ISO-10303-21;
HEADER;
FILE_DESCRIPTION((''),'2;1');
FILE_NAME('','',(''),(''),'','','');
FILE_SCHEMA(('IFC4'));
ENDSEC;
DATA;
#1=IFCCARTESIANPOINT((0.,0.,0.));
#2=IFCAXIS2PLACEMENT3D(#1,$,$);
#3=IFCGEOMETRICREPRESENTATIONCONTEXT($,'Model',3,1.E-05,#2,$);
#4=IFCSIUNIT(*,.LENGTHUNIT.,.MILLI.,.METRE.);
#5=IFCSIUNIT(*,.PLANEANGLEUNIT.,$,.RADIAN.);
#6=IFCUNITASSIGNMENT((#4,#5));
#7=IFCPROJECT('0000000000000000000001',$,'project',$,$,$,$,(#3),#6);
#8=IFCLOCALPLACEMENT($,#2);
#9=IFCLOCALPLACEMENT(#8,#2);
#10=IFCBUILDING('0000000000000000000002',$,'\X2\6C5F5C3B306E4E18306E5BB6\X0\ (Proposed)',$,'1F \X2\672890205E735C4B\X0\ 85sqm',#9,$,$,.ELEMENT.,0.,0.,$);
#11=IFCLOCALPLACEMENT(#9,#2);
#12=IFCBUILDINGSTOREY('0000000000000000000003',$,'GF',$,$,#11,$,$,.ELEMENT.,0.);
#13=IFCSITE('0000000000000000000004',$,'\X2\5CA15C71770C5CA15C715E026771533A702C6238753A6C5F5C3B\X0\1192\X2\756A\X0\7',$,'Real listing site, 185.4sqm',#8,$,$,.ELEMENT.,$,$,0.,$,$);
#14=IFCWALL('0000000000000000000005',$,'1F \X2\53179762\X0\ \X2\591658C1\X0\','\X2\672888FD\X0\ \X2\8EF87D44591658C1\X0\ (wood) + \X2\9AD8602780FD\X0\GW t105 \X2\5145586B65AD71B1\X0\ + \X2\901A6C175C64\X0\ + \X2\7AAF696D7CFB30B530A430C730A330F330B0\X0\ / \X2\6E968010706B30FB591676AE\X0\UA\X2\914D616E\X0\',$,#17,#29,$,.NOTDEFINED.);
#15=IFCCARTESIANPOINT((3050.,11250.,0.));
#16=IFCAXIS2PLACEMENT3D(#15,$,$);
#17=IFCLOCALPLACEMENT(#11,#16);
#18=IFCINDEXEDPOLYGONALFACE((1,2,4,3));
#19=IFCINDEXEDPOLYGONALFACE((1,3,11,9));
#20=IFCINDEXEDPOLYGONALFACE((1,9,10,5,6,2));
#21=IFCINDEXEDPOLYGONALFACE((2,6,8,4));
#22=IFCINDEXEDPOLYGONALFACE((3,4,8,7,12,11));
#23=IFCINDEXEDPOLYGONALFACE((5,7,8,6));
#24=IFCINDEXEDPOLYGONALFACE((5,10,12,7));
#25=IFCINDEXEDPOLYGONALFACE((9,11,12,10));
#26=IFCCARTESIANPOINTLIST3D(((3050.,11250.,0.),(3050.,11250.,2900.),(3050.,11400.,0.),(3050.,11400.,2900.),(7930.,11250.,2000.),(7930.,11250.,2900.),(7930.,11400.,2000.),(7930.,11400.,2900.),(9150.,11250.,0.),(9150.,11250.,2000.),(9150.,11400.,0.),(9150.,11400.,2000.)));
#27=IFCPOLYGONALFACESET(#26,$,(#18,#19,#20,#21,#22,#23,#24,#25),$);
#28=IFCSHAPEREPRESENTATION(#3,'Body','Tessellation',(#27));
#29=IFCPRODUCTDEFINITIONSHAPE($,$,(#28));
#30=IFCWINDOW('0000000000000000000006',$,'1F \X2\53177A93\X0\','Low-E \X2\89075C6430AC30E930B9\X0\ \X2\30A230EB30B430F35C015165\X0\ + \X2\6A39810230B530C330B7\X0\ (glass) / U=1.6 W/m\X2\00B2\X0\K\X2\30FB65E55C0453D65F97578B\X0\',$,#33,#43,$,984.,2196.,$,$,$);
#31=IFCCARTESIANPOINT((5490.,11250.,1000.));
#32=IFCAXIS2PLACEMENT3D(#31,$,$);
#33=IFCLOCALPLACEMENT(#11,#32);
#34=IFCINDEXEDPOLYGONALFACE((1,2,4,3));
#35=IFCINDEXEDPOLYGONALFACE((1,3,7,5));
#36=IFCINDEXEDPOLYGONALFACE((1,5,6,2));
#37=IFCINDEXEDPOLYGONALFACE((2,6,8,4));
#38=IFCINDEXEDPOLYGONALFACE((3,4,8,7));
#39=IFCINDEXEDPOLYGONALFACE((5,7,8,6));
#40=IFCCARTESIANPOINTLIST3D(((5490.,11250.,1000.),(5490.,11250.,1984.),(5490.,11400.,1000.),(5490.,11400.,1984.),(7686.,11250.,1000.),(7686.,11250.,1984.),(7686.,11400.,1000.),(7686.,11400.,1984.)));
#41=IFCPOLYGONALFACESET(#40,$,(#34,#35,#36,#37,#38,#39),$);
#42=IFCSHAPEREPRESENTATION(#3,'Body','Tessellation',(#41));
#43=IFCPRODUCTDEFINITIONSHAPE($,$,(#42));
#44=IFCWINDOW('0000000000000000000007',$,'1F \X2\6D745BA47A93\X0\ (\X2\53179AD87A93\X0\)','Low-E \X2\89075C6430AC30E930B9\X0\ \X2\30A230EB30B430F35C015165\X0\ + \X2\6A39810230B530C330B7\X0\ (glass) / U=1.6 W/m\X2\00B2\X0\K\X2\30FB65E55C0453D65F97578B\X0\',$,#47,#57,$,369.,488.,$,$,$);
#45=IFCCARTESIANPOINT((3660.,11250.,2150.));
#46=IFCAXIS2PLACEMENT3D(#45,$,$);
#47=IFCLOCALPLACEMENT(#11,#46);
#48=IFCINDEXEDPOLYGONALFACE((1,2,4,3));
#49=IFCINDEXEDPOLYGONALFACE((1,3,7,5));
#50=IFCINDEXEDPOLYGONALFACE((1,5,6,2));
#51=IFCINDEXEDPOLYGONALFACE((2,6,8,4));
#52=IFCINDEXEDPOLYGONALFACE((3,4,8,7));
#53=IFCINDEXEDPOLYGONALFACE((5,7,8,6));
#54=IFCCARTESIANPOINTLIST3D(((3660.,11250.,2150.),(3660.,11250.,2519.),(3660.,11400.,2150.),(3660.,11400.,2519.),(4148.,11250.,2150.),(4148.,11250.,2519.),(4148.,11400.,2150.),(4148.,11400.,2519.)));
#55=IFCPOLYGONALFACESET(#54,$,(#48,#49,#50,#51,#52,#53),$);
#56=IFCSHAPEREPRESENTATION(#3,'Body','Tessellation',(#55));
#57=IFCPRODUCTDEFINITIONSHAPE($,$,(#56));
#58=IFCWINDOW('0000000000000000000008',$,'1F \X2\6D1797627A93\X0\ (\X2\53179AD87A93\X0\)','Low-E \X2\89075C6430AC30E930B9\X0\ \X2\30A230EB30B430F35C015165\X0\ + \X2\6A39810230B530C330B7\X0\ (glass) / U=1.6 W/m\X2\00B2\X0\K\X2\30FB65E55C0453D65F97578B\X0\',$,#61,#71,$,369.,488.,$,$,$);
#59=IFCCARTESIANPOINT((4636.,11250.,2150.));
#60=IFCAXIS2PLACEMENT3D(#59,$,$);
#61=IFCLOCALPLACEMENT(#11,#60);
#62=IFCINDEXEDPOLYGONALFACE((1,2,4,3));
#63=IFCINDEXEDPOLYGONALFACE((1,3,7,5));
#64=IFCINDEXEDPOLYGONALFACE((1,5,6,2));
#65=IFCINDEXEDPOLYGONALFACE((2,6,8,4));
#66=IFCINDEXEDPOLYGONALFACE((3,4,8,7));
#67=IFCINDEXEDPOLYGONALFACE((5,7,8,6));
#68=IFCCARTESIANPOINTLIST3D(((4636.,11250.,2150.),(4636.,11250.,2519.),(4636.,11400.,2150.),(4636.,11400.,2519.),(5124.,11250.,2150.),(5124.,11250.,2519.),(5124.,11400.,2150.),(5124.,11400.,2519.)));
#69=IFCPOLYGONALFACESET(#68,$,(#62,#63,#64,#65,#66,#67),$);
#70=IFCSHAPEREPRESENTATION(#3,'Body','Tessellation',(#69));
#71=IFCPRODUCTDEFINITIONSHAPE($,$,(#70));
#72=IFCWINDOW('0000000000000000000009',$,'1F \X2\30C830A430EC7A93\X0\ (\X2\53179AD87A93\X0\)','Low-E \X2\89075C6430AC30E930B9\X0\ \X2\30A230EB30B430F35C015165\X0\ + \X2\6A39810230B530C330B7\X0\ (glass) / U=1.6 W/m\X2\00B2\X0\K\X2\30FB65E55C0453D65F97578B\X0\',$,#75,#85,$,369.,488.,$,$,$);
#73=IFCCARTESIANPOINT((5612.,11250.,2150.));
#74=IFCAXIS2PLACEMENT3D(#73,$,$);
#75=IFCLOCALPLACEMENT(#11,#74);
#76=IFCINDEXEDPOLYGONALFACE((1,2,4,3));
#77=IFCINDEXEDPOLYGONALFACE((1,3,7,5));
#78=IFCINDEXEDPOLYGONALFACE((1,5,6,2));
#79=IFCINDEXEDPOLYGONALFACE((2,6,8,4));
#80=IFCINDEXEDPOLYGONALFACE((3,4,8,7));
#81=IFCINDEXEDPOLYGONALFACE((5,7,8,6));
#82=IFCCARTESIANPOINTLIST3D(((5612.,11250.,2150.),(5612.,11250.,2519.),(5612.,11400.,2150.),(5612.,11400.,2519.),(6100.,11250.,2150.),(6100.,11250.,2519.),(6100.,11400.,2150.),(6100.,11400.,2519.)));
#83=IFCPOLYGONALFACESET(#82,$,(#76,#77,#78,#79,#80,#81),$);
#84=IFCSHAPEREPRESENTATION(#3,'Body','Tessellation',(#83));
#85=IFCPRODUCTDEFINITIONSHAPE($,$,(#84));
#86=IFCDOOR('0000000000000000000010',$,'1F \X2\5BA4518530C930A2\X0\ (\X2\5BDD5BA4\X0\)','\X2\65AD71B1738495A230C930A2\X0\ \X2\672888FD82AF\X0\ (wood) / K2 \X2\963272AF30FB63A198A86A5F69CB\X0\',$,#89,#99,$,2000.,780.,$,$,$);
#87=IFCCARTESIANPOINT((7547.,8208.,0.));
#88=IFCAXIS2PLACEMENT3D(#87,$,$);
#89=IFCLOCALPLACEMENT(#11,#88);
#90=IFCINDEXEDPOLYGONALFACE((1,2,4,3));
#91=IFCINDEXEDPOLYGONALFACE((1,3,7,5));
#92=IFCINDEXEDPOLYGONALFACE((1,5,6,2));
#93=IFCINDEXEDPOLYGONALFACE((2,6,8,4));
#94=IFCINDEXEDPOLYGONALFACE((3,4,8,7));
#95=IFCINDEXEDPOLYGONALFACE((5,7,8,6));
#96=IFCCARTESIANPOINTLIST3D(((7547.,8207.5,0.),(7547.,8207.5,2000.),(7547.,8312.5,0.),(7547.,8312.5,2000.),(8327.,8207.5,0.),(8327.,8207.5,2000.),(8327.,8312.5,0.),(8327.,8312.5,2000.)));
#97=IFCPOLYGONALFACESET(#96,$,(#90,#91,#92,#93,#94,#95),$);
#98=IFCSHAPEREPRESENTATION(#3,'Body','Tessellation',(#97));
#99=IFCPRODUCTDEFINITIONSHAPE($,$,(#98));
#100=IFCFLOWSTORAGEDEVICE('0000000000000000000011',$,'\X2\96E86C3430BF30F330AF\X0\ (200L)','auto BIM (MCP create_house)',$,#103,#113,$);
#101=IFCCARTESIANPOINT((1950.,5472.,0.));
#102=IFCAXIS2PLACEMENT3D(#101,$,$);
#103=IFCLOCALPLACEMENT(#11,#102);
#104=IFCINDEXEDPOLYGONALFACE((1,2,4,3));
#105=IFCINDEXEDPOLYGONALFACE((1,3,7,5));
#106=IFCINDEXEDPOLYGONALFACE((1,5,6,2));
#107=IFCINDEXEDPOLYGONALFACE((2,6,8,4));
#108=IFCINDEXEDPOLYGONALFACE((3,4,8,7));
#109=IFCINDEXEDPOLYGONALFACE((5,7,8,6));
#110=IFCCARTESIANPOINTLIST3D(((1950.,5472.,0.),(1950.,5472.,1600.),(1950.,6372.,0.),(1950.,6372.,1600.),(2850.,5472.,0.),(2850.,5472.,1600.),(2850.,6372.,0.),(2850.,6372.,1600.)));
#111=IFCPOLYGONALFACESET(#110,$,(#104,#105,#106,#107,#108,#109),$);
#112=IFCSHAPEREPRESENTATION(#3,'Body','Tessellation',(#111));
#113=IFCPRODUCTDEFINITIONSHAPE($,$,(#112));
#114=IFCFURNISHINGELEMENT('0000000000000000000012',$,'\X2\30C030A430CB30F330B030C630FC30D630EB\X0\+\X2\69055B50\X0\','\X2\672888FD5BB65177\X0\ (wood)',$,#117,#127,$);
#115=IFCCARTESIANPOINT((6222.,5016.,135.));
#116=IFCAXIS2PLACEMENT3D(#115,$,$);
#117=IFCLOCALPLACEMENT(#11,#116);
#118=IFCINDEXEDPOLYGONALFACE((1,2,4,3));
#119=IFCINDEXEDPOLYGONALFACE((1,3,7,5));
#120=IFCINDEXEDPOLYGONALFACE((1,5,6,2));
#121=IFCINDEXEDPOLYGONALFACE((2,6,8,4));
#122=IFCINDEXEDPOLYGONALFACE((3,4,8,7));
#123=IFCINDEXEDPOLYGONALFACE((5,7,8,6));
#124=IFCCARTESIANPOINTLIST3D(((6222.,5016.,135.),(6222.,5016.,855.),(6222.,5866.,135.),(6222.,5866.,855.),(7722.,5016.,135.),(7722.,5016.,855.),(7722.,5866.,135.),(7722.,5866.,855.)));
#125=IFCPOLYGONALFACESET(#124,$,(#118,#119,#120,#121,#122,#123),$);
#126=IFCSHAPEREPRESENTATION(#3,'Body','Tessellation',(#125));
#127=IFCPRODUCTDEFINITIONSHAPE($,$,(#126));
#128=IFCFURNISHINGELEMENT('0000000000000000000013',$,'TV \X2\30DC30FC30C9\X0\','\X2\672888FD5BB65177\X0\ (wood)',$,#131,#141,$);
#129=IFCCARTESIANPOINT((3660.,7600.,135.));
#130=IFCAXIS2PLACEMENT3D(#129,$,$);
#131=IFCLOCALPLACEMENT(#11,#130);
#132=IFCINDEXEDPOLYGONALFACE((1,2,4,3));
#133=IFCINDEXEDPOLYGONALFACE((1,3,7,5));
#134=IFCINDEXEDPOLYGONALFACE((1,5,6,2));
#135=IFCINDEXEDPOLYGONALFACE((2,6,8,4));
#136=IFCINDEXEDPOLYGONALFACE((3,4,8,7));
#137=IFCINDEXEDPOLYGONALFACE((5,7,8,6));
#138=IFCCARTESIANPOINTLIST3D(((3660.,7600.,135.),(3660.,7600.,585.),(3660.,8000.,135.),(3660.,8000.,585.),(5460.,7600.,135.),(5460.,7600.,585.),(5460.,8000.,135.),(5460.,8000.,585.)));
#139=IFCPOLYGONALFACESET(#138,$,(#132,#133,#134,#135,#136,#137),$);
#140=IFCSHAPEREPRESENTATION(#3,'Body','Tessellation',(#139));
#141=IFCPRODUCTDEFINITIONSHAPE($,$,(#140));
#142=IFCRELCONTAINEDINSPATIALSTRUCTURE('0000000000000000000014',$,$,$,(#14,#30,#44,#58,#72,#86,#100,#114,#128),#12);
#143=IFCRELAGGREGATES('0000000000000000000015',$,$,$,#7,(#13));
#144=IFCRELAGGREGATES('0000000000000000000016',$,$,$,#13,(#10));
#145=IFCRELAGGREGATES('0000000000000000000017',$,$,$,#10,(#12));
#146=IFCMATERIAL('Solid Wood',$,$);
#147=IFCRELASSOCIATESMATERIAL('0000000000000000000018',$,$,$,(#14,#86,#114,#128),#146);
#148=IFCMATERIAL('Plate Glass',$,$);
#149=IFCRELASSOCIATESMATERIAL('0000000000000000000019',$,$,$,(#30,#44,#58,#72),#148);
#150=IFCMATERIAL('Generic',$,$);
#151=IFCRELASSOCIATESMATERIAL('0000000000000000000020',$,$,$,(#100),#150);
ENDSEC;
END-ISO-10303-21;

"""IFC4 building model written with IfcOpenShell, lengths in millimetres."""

from ifc_helpers import new_model, si_unit, frame, frame_2d, origin, place, context, project, spatial, rectangle, extrude, material, element, fill, save


model = new_model("IFC4")

# Units and contexts
model_context = context("Model", 3, precision=1e-05, world=origin())
ifc_project = project(units=[si_unit("LENGTHUNIT", "METRE", prefix="MILLI"), si_unit("PLANEANGLEUNIT", "RADIAN")], contexts=[model_context])

# Site, building, storey
site_placement = place(None, origin())
site = spatial("IfcSite", under=ifc_project, at=site_placement, Name="岡山県岡山市東区瀬戸町江尻1192番7", ObjectType="Real listing site, 185.4sqm", CompositionType="ELEMENT", RefElevation=0.0)
building_placement = place(site_placement, origin())
building = spatial("IfcBuilding", under=site, at=building_placement, Name="江尻の丘の家 (Proposed)", ObjectType="1F 木造平屋 85sqm", CompositionType="ELEMENT", ElevationOfRefHeight=0.0, ElevationOfTerrain=0.0)
storey_placement = place(building_placement, origin())
storey = spatial("IfcBuildingStorey", under=building, at=storey_placement, Name="GF", CompositionType="ELEMENT", Elevation=0.0)

# Wall, openings, windows
ifc_material_1 = material(Name="Solid Wood")
wall_1_placement = place(storey_placement, frame((3050.0, 11250.0, 0.0)))
wall_1 = element("IfcWall", 1, at=wall_1_placement, inside=storey, material=ifc_material_1, Name="1F 北面 外壁", Description="木製 軸組外壁 (wood) + 高性能GW t105 充填断熱 + 通気層 + 窯業系サイディング / 準耐火・外皮UA配慮", PredefinedType="NOTDEFINED", context=model_context, shape_type="SweptSolid", body=[
    extrude(rectangle(XDim=6100.0, YDim=150.0, at=frame_2d((3050.0, 75.0))), frame((3050.0, 11250.0, 0.0)), (0.0, 0.0, 1.0), 2900.0),
])
opening_1_placement = place(storey_placement, frame((5490.0, 11250.0, 1000.0)))
opening_1 = element("IfcOpeningElement", 2, at=opening_1_placement, cuts=wall_1, PredefinedType="NOTDEFINED", context=model_context, shape_type="SweptSolid", body=[
    extrude(rectangle(XDim=2196.0, YDim=150.0, at=frame_2d((1098.0, 75.0))), frame((5490.0, 11250.0, 1000.0)), (0.0, 0.0, 1.0), 984.0),
])
opening_2_placement = place(storey_placement, frame((3660.0, 11250.0, 2150.0)))
opening_2 = element("IfcOpeningElement", 3, at=opening_2_placement, cuts=wall_1, PredefinedType="NOTDEFINED", context=model_context, shape_type="SweptSolid", body=[
    extrude(rectangle(XDim=488.0, YDim=150.0, at=frame_2d((244.0, 75.0))), frame((3660.0, 11250.0, 2150.0)), (0.0, 0.0, 1.0), 369.0),
])
opening_3_placement = place(storey_placement, frame((4636.0, 11250.0, 2150.0)))
opening_3 = element("IfcOpeningElement", 4, at=opening_3_placement, cuts=wall_1, PredefinedType="NOTDEFINED", context=model_context, shape_type="SweptSolid", body=[
    extrude(rectangle(XDim=488.0, YDim=150.0, at=frame_2d((244.0, 75.0))), frame((4636.0, 11250.0, 2150.0)), (0.0, 0.0, 1.0), 369.0),
])
opening_4_placement = place(storey_placement, frame((5612.0, 11250.0, 2150.0)))
opening_4 = element("IfcOpeningElement", 5, at=opening_4_placement, cuts=wall_1, PredefinedType="NOTDEFINED", context=model_context, shape_type="SweptSolid", body=[
    extrude(rectangle(XDim=488.0, YDim=150.0, at=frame_2d((244.0, 75.0))), frame((5612.0, 11250.0, 2150.0)), (0.0, 0.0, 1.0), 369.0),
])
ifc_material_2 = material(Name="Plate Glass")
window_1_placement = place(storey_placement, frame((5490.0, 11250.0, 1000.0)))
window_1 = element("IfcWindow", 6, at=window_1_placement, inside=storey, material=ifc_material_2, Name="1F 北窓", Description="Low-E 複層ガラス アルゴン封入 + 樹脂サッシ (glass) / U=1.6 W/m²K・日射取得型", OverallHeight=984.0, OverallWidth=2196.0, context=model_context, shape_type="SweptSolid", body=[
    extrude(rectangle(XDim=2196.0, YDim=150.0, at=frame_2d((1098.0, 75.0))), frame((5490.0, 11250.0, 1000.0)), (0.0, 0.0, 1.0), 984.0),
])
fill(opening_1, window_1)
window_2_placement = place(storey_placement, frame((3660.0, 11250.0, 2150.0)))
window_2 = element("IfcWindow", 7, at=window_2_placement, inside=storey, material=ifc_material_2, Name="1F 浴室窓 (北高窓)", Description="Low-E 複層ガラス アルゴン封入 + 樹脂サッシ (glass) / U=1.6 W/m²K・日射取得型", OverallHeight=369.0, OverallWidth=488.0, context=model_context, shape_type="SweptSolid", body=[
    extrude(rectangle(XDim=488.0, YDim=150.0, at=frame_2d((244.0, 75.0))), frame((3660.0, 11250.0, 2150.0)), (0.0, 0.0, 1.0), 369.0),
])
fill(opening_2, window_2)
window_3_placement = place(storey_placement, frame((4636.0, 11250.0, 2150.0)))
window_3 = element("IfcWindow", 8, at=window_3_placement, inside=storey, material=ifc_material_2, Name="1F 洗面窓 (北高窓)", Description="Low-E 複層ガラス アルゴン封入 + 樹脂サッシ (glass) / U=1.6 W/m²K・日射取得型", OverallHeight=369.0, OverallWidth=488.0, context=model_context, shape_type="SweptSolid", body=[
    extrude(rectangle(XDim=488.0, YDim=150.0, at=frame_2d((244.0, 75.0))), frame((4636.0, 11250.0, 2150.0)), (0.0, 0.0, 1.0), 369.0),
])
fill(opening_3, window_3)
window_4_placement = place(storey_placement, frame((5612.0, 11250.0, 2150.0)))
window_4 = element("IfcWindow", 9, at=window_4_placement, inside=storey, material=ifc_material_2, Name="1F トイレ窓 (北高窓)", Description="Low-E 複層ガラス アルゴン封入 + 樹脂サッシ (glass) / U=1.6 W/m²K・日射取得型", OverallHeight=369.0, OverallWidth=488.0, context=model_context, shape_type="SweptSolid", body=[
    extrude(rectangle(XDim=488.0, YDim=150.0, at=frame_2d((244.0, 75.0))), frame((5612.0, 11250.0, 2150.0)), (0.0, 0.0, 1.0), 369.0),
])
fill(opening_4, window_4)

# Door
door_1_placement = place(storey_placement, frame((7547.0, 8208.0, 0.0)))
element("IfcDoor", 10, at=door_1_placement, inside=storey, material=ifc_material_1, Name="1F 室内ドア (寝室)", Description="断熱玄関ドア 木製芯 (wood) / K2 防犯・採風機構", OverallHeight=2000.0, OverallWidth=780.0, context=model_context, shape_type="SweptSolid", body=[
    extrude(rectangle(XDim=780.0, YDim=105.0, at=frame_2d((390.0, 52.0))), frame((7547.0, 8208.0, 0.0)), (0.0, 0.0, 1.0), 2000.0),
])

# Flow storage device
ifc_material_3 = material(Name="Generic")
flow_storage_device_placement = place(storey_placement, frame((1950.0, 5472.0, 0.0)))
element("IfcFlowStorageDevice", 11, at=flow_storage_device_placement, inside=storey, material=ifc_material_3, Name="雨水タンク (200L)", Description="auto BIM (MCP create_house)", context=model_context, shape_type="SweptSolid", body=[
    extrude(rectangle(XDim=900.0, YDim=900.0, at=frame_2d((450.0, 450.0))), frame((1950.0, 5472.0, 0.0)), (0.0, 0.0, 1.0), 1600.0),
])

# Furnishing elements
furnishing_1_placement = place(storey_placement, frame((6222.0, 5016.0, 135.0)))
element("IfcFurnishingElement", 12, at=furnishing_1_placement, inside=storey, material=ifc_material_1, Name="ダイニングテーブル+椅子", Description="木製家具 (wood)", context=model_context, shape_type="SweptSolid", body=[
    extrude(rectangle(XDim=1500.0, YDim=850.0, at=frame_2d((750.0, 425.0))), frame((6222.0, 5016.0, 135.0)), (0.0, 0.0, 1.0), 720.0),
])
furnishing_2_placement = place(storey_placement, frame((3660.0, 7600.0, 135.0)))
element("IfcFurnishingElement", 13, at=furnishing_2_placement, inside=storey, material=ifc_material_1, Name="TV ボード", Description="木製家具 (wood)", context=model_context, shape_type="SweptSolid", body=[
    extrude(rectangle(XDim=1800.0, YDim=400.0, at=frame_2d((900.0, 200.0))), frame((3660.0, 7600.0, 135.0)), (0.0, 0.0, 1.0), 450.0),
])

save(model, "model.ifc")
